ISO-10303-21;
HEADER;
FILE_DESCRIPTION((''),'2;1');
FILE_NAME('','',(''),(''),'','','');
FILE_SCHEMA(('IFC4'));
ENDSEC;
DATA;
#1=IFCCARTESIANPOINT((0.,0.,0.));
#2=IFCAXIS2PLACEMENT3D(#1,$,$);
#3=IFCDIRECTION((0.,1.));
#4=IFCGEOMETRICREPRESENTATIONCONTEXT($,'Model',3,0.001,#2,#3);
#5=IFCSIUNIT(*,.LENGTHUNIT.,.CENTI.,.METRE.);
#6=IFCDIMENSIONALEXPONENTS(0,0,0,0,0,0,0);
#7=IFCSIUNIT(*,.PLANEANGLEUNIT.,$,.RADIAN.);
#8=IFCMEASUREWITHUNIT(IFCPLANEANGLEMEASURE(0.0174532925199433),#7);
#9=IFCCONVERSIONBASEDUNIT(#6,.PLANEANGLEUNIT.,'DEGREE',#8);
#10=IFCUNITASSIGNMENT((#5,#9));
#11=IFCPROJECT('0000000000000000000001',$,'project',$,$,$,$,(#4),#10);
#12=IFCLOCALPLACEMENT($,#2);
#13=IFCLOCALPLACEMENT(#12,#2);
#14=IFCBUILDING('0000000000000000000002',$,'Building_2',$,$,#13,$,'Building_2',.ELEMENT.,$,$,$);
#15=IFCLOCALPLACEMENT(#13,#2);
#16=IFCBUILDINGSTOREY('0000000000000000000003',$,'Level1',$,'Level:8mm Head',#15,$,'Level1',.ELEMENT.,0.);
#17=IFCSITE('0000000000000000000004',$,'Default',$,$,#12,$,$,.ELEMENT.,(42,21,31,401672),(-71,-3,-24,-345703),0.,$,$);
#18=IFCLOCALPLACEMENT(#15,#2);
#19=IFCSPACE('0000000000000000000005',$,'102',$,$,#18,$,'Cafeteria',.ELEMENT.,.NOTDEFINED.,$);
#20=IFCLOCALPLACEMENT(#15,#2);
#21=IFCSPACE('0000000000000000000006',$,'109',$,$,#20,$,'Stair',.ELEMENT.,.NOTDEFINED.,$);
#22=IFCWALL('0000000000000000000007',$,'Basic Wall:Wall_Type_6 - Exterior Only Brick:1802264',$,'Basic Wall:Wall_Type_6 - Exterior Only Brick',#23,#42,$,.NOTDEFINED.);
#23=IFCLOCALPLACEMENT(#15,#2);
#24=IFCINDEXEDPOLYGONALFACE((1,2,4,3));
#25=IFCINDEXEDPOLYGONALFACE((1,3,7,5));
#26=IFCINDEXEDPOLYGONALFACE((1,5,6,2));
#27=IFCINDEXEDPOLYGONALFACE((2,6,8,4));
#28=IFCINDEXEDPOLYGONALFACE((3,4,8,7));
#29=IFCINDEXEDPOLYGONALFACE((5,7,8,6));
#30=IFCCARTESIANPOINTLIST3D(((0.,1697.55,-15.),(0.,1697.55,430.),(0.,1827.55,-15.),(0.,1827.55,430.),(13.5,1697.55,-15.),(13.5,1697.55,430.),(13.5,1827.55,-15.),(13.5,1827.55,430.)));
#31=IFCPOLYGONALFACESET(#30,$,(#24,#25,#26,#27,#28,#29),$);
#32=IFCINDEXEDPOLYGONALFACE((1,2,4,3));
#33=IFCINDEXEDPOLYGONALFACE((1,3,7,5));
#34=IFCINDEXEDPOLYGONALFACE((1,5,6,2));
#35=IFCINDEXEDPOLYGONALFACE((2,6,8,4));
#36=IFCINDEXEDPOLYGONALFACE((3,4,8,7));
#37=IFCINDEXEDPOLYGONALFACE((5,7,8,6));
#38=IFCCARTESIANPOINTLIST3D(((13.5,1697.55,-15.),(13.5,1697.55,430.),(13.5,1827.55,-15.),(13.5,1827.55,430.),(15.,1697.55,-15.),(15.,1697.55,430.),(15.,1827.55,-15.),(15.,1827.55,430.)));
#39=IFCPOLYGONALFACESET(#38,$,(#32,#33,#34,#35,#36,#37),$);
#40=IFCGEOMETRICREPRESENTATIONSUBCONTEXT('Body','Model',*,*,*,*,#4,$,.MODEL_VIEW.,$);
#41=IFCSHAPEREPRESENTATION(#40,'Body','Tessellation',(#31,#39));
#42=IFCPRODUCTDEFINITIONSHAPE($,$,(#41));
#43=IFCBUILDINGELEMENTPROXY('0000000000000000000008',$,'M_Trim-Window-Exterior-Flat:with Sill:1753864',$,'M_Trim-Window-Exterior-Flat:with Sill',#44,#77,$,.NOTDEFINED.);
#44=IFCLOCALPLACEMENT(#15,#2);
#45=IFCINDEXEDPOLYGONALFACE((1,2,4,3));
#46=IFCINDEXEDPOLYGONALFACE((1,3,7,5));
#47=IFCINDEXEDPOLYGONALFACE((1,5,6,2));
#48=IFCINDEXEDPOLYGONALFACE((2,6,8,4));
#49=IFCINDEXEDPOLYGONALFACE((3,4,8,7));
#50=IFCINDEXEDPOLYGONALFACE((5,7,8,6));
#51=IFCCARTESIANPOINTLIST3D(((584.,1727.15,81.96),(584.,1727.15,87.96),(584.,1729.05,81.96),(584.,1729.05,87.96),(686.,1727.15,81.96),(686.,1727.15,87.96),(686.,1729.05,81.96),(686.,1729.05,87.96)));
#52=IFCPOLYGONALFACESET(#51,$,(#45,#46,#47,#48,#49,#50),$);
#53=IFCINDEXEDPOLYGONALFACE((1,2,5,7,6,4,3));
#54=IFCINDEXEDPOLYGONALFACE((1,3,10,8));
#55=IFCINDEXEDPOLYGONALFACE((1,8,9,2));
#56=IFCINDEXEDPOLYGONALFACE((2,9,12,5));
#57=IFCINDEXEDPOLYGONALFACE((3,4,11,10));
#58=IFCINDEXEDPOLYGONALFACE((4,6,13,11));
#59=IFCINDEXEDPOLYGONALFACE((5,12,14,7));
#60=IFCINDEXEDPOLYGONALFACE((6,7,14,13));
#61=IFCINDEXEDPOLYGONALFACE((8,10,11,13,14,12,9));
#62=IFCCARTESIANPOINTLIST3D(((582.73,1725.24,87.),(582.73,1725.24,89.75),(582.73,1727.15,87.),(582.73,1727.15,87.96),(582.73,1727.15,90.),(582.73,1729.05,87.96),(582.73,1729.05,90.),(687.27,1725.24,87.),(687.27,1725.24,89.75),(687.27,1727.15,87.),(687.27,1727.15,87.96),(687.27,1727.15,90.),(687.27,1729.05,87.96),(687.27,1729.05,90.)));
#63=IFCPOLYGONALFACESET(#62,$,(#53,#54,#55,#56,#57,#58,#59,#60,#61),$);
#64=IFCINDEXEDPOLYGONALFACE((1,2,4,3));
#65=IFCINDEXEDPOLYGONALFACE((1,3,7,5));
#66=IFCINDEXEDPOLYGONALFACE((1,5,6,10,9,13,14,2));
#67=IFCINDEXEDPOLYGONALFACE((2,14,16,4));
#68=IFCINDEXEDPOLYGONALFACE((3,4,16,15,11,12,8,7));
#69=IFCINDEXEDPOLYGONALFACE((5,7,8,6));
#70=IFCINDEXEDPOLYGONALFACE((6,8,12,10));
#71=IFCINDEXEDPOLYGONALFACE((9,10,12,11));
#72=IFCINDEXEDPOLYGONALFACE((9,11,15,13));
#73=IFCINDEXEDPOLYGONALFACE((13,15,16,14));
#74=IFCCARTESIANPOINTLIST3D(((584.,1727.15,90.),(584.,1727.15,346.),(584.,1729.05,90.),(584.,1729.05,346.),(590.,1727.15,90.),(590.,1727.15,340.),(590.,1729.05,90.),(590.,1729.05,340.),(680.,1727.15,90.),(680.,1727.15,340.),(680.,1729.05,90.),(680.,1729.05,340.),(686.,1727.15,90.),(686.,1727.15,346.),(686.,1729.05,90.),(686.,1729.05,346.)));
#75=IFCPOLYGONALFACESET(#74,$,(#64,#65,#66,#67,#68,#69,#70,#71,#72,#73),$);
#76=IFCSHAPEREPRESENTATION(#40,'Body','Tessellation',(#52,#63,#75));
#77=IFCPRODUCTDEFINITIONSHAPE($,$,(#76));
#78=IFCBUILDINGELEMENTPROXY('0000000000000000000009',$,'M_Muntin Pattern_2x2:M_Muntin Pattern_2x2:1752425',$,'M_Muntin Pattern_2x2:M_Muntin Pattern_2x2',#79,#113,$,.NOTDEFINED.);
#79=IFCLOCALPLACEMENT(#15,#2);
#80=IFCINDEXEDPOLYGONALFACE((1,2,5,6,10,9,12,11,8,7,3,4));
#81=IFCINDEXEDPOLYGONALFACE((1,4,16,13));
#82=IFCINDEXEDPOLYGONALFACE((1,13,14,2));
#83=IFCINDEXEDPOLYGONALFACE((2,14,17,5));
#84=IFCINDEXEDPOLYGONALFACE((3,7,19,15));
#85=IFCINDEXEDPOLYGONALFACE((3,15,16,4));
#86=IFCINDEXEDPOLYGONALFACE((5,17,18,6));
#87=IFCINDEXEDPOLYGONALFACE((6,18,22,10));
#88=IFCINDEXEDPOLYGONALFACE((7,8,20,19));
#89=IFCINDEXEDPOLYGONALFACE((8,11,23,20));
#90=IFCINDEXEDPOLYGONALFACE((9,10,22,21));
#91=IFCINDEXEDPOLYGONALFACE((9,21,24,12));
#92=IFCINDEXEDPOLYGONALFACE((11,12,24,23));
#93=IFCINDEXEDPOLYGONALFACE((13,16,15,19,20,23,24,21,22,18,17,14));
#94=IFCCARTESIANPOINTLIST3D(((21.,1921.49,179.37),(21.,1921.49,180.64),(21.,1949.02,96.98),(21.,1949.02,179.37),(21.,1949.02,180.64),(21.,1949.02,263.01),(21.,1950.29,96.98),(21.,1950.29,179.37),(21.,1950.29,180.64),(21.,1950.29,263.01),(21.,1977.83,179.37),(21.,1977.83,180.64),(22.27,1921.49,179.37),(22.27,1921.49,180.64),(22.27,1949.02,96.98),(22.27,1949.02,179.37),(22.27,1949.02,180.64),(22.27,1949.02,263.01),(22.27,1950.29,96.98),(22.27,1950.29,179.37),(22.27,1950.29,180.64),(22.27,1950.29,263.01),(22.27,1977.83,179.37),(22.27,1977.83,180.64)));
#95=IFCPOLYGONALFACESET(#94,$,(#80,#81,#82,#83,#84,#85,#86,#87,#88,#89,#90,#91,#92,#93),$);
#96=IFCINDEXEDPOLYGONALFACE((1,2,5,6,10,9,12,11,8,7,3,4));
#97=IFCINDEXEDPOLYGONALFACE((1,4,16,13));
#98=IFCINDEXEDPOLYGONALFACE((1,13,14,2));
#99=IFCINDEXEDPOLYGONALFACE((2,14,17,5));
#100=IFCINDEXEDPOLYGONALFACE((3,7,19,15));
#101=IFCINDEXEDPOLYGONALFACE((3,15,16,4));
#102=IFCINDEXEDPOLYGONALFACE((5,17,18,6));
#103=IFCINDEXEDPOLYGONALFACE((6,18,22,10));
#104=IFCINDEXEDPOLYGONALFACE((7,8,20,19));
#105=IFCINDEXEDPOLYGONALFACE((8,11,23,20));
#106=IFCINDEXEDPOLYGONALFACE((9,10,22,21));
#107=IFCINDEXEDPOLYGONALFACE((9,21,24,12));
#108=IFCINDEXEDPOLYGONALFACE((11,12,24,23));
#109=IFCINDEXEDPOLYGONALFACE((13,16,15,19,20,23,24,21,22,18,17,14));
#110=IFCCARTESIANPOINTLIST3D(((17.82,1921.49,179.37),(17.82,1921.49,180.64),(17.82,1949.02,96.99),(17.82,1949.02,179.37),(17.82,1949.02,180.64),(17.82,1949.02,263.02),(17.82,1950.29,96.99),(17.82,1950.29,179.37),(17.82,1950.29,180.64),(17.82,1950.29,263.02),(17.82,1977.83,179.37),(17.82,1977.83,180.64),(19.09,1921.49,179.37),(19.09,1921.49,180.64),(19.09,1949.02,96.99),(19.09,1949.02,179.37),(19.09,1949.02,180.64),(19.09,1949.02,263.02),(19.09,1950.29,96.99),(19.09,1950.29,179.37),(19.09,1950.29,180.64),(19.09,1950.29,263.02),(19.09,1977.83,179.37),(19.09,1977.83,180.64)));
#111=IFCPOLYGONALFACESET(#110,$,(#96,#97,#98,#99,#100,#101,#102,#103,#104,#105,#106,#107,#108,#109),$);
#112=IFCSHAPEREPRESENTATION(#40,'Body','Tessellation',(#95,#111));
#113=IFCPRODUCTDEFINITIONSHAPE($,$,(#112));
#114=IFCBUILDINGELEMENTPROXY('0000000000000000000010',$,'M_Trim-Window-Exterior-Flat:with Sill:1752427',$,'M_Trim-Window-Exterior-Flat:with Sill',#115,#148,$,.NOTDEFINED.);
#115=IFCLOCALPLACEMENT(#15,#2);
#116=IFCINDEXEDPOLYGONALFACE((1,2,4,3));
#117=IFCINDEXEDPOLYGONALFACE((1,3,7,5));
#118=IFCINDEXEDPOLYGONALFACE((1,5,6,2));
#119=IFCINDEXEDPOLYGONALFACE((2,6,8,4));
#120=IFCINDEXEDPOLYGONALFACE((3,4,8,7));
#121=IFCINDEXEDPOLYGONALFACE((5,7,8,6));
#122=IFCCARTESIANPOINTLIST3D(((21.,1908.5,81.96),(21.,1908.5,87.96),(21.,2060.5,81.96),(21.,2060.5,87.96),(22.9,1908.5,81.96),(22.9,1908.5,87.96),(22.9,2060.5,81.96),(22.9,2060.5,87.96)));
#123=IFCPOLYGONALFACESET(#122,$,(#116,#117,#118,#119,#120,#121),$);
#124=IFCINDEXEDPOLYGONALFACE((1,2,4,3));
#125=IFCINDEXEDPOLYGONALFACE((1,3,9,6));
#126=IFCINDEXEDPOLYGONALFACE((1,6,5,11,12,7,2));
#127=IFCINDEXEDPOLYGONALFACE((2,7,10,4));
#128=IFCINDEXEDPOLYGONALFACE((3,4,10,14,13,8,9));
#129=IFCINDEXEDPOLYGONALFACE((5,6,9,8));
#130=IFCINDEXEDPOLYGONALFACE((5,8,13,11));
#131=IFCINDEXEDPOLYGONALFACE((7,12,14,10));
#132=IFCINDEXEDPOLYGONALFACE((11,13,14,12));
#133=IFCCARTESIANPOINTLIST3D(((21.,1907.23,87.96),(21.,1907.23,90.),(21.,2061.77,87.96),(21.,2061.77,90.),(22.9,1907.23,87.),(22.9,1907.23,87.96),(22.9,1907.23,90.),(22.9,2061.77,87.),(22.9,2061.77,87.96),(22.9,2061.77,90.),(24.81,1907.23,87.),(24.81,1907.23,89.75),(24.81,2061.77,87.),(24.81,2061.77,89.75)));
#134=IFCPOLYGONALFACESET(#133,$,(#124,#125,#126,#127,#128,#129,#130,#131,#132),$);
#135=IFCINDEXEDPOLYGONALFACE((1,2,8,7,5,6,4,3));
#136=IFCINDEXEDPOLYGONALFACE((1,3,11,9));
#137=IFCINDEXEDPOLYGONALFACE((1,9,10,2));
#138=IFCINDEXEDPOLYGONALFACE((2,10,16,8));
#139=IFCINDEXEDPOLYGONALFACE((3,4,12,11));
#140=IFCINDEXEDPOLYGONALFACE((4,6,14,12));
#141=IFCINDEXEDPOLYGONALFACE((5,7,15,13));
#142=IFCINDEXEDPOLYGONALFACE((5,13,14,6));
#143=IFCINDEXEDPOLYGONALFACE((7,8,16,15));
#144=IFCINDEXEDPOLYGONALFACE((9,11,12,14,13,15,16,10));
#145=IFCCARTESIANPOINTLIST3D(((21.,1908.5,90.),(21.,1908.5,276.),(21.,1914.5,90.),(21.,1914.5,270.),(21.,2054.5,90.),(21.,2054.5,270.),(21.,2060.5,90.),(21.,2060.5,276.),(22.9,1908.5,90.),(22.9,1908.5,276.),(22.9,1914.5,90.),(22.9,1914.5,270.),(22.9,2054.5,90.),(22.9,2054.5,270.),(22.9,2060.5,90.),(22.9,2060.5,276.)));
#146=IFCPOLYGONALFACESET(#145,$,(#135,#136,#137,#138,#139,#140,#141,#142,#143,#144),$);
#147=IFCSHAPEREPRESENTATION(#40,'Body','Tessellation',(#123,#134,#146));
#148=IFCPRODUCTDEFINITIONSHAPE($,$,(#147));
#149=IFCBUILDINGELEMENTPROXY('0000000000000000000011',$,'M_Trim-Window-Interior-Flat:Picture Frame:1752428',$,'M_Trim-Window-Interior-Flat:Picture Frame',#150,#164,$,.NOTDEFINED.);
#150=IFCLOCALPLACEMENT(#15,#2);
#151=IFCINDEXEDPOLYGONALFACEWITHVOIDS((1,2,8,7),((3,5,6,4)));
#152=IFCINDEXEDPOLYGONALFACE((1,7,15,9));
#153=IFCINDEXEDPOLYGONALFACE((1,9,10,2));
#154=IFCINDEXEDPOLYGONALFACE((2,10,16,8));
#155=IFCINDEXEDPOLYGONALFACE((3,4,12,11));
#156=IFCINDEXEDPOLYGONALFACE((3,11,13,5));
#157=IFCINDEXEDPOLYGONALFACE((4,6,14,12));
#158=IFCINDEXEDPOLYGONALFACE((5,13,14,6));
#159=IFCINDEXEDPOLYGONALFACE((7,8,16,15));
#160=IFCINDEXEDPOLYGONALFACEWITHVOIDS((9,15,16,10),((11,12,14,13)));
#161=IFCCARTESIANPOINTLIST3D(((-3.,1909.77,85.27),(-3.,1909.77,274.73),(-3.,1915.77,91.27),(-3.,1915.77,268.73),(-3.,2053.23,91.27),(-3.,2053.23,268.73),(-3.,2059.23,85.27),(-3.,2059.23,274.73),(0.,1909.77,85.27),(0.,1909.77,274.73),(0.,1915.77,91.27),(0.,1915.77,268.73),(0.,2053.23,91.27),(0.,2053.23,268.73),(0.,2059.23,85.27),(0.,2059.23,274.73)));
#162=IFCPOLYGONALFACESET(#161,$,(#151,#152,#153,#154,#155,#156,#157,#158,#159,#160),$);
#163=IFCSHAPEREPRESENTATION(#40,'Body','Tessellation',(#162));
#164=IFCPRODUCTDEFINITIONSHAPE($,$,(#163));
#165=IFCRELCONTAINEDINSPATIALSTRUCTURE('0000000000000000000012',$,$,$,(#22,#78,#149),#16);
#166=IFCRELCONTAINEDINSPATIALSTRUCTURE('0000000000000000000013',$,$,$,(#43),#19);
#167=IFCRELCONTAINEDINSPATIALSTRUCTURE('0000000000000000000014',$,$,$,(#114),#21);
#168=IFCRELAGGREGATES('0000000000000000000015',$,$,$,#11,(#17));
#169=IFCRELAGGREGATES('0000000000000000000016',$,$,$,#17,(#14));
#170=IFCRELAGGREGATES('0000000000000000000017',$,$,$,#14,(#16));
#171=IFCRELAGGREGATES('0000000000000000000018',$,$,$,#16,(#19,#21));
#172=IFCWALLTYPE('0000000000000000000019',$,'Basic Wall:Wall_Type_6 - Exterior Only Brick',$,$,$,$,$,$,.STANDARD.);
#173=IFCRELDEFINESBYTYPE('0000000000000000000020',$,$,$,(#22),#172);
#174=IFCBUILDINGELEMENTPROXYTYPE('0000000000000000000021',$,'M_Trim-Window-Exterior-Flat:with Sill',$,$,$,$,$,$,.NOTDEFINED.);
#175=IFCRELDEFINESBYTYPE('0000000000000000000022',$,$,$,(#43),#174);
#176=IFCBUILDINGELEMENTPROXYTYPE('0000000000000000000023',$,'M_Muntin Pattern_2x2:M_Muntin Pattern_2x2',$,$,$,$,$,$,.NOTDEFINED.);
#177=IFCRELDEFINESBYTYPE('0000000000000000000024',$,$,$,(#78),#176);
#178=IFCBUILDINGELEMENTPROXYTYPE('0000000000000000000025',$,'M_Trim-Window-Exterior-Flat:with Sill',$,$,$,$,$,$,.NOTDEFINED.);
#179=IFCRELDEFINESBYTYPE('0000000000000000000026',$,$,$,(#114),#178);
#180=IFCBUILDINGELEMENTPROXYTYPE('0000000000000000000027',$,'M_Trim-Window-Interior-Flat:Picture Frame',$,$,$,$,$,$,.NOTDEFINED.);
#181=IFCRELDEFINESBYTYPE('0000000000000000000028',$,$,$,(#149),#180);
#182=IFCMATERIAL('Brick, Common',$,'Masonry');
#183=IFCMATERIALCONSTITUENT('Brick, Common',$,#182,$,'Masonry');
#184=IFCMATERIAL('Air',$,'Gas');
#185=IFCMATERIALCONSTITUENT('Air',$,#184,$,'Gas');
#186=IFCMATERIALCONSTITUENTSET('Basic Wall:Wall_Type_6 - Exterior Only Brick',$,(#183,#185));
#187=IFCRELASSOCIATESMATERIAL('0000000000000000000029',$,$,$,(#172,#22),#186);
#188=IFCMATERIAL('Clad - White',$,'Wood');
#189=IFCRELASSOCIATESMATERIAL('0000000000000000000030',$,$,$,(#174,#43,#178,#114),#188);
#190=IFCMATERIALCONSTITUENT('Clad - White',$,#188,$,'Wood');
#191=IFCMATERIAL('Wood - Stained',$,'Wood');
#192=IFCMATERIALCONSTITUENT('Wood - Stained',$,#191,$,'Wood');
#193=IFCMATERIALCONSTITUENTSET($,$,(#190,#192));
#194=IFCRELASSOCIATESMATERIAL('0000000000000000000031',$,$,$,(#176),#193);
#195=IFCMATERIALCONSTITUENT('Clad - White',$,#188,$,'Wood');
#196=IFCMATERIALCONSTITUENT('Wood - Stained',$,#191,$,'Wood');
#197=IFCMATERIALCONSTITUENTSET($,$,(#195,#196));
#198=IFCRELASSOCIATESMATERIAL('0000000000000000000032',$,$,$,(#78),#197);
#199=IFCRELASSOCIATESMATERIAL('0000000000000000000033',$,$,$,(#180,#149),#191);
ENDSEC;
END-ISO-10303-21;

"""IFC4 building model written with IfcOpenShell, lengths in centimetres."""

from ifc_helpers import new_model, entity, si_unit, converted_unit, direction, frame, origin, place, context, subcontext, project, spatial, indexed_curve, outline, extrude, source, transform, mapped, material, constituent, constituent_set, type_object, type_shapes, element, save


model = new_model("IFC4")

# Units and contexts
model_context = context("Model", 3, precision=0.001, world=origin(), true_north=direction((0.0, 1.0)))
body_context = subcontext(model_context, "Body", "Model", "MODEL_VIEW")
ifc_project = project(units=[si_unit("LENGTHUNIT", "METRE", prefix="CENTI"), converted_unit("PLANEANGLEUNIT", "DEGREE", entity("IfcPlaneAngleMeasure", 0.0174532925199433), si_unit("PLANEANGLEUNIT", "RADIAN"), dimensions=[0, 0, 0, 0, 0, 0, 0])], contexts=[model_context])

# Site, building, storey
site_placement = place(None, origin())
site = spatial("IfcSite", under=ifc_project, at=site_placement, Name="Default", CompositionType="ELEMENT", RefLatitude=(42, 21, 31, 401672), RefLongitude=(-71, -3, -24, -345703), RefElevation=0.0)
building_placement = place(site_placement, origin())
building = spatial("IfcBuilding", under=site, at=building_placement, Name="Building_2", LongName="Building_2", CompositionType="ELEMENT")
storey_placement = place(building_placement, origin())
storey = spatial("IfcBuildingStorey", under=building, at=storey_placement, Name="Level1", ObjectType="Level:8mm Head", LongName="Level1", CompositionType="ELEMENT", Elevation=0.0)

# Shared definitions
ifc_material_1 = material(Name="Brick, Common", Category="Masonry")
ifc_material_2 = material(Name="Air", Category="Gas")

# Shared definitions
ifc_constituent_1 = constituent(ifc_material_1, Name="Brick, Common", Category="Masonry")
ifc_constituent_2 = constituent(ifc_material_2, Name="Air", Category="Gas")
ifc_constituent_set_1 = constituent_set(constituents=[ifc_constituent_1, ifc_constituent_2], Name="Basic Wall:Wall_Type_6 - Exterior Only Brick")
wall_type_1 = type_object("IfcWallType", Name="Basic Wall:Wall_Type_6 - Exterior Only Brick", PredefinedType="STANDARD", material=ifc_constituent_set_1)

# Wall
wall_1_placement = place(storey_placement, frame((7.5, 1697.55, -15.0), z_axis=(0.0, 0.0, 1.0), x_axis=(0.0, 1.0, 0.0)))
element("IfcWall", 1, at=wall_1_placement, inside=storey, type_object=wall_type_1, material=ifc_constituent_set_1, Name="Basic Wall:Wall_Type_6 - Exterior Only Brick:1802264", ObjectType="Basic Wall:Wall_Type_6 - Exterior Only Brick", PredefinedType="NOTDEFINED", context=body_context, shape_type="SweptSolid", body=[
    extrude(outline(indexed_curve([(-6.75, -65.0), (6.75, -65.0), (6.75, 65.0), (-6.75, 65.0), (-6.75, -65.0)], self_intersect=False)), frame((65.0, 0.75, 0.0), z_axis=(0.0, 0.0, 1.0), x_axis=(0.0, -1.0, 0.0)), (0.0, 0.0, 1.0), 445.0),
    extrude(outline(indexed_curve([(-0.75, -65.0), (0.75, -65.0), (0.75, 65.0), (-0.75, 65.0), (-0.75, -65.0)], self_intersect=False)), frame((65.0, -6.75, 0.0), z_axis=(0.0, 0.0, 1.0), x_axis=(0.0, 1.0, 0.0)), (0.0, 0.0, 1.0), 445.0),
])

# Shared definitions
space_1_placement = place(storey_placement, origin())
space_1 = spatial("IfcSpace", under=storey, at=space_1_placement, Name="102", LongName="Cafeteria", CompositionType="ELEMENT", PredefinedType="NOTDEFINED")

# Building element proxies
ifc_material_3 = material(Name="Clad - White", Category="Wood")
building_element_proxy_type_1 = type_object("IfcBuildingElementProxyType", Name="M_Trim-Window-Exterior-Flat:with Sill", PredefinedType="NOTDEFINED", material=ifc_material_3)
shared_shape_1 = source(origin(), body_context, "Body", "SweptSolid", [
    extrude(outline(indexed_curve([(-3.0, -51.0), (3.0, -51.0), (3.0, 51.0), (-3.0, 51.0), (-3.0, -51.0)], self_intersect=False)), frame((0.0, 255.04, 0.0), z_axis=(0.0, 0.0, 1.0), x_axis=(0.0, 1.0, 0.0)), (0.0, 0.0, 1.0), 1.91),
    extrude(outline(indexed_curve([(-1.52, -1.9), (1.23, -1.9), (1.48, 0.0), (1.48, 1.9), (-0.57, 1.9), (-0.57, 0.0), (-1.52, 0.0), (-1.52, -1.9)], self_intersect=False)), frame((-52.27, 251.48, 1.9), z_axis=(1.0, 0.0, 0.0), x_axis=(0.0, -1.0, 0.0)), (0.0, 0.0, 1.0), 104.54),
    extrude(outline(indexed_curve([(-51.0, -129.5), (51.0, -129.5), (51.0, 126.5), (45.0, 126.5), (45.0, -123.5), (-45.0, -123.5), (-45.0, 126.5), (-51.0, 126.5), (-51.0, -129.5)], self_intersect=False)), frame((0.0, 123.5, 0.0)), (0.0, 0.0, 1.0), 1.91),
])
type_shapes(building_element_proxy_type_1, [shared_shape_1])
proxy_1_placement = place(space_1_placement, frame((635.0, 1729.05, 340.0), z_axis=(0.0, -1.0, 0.0), x_axis=(-1.0, 0.0, 0.0)))
element("IfcBuildingElementProxy", 2, at=proxy_1_placement, inside=space_1, type_object=building_element_proxy_type_1, material=ifc_material_3, Name="M_Trim-Window-Exterior-Flat:with Sill:1753864", ObjectType="M_Trim-Window-Exterior-Flat:with Sill", PredefinedType="NOTDEFINED", context=body_context, shape_type="MappedRepresentation", body=[
    mapped(shared_shape_1, transform((0.0, 0.0, 0.0), scale=1.0)),
])
ifc_constituent_3 = constituent(ifc_material_3, Name="Clad - White", Category="Wood")
ifc_material_4 = material(Name="Wood - Stained", Category="Wood")
ifc_constituent_4 = constituent(ifc_material_4, Name="Wood - Stained", Category="Wood")
ifc_constituent_set_2 = constituent_set(constituents=[ifc_constituent_3, ifc_constituent_4])
ifc_constituent_5 = constituent(ifc_material_3, Name="Clad - White", Category="Wood")
ifc_constituent_6 = constituent(ifc_material_4, Name="Wood - Stained", Category="Wood")
ifc_constituent_set_3 = constituent_set(constituents=[ifc_constituent_5, ifc_constituent_6])
building_element_proxy_type_2 = type_object("IfcBuildingElementProxyType", Name="M_Muntin Pattern_2x2:M_Muntin Pattern_2x2", PredefinedType="NOTDEFINED", material=ifc_constituent_set_3)
shared_shape_2 = source(origin(), body_context, "Body", "SweptSolid", [
    extrude(outline(indexed_curve([(0.64, -0.64), (83.01, -0.64), (83.01, 0.63), (0.64, 0.63), (0.64, 28.17), (-0.63, 28.17), (-0.63, 0.63), (-83.02, 0.63), (-83.02, -0.64), (-0.63, -0.64), (-0.63, -28.17), (0.64, -28.17), (0.64, -0.64)], self_intersect=False)), frame((0.0, -2.22, 83.01), z_axis=(0.0, 1.0, 0.0), x_axis=(0.0, 0.0, 1.0)), (0.0, 0.0, 1.0), 1.27),
    extrude(outline(indexed_curve([(0.64, -0.64), (83.02, -0.64), (83.02, 0.63), (0.64, 0.63), (0.64, 28.17), (-0.63, 28.17), (-0.63, 0.63), (-83.02, 0.63), (-83.02, -0.64), (-0.63, -0.64), (-0.63, -28.17), (0.64, -28.17), (0.64, -0.64)], self_intersect=False)), frame((0.0, 0.95, 83.02), z_axis=(0.0, 1.0, 0.0), x_axis=(0.0, 0.0, 1.0)), (0.0, 0.0, 1.0), 1.27),
])
type_shapes(building_element_proxy_type_2, [shared_shape_2])
proxy_2_placement = place(storey_placement, frame((20.05, 1949.66, 96.99), z_axis=(0.0, 0.0, 1.0), x_axis=(0.0, 1.0, 0.0)))
element("IfcBuildingElementProxy", 3, at=proxy_2_placement, inside=storey, type_object=building_element_proxy_type_2, material=ifc_constituent_set_2, Name="M_Muntin Pattern_2x2:M_Muntin Pattern_2x2:1752425", ObjectType="M_Muntin Pattern_2x2:M_Muntin Pattern_2x2", PredefinedType="NOTDEFINED", context=body_context, shape_type="MappedRepresentation", body=[
    mapped(shared_shape_2, transform((0.0, 0.0, 0.0), scale=1.0)),
])

# Shared definitions
space_2_placement = place(storey_placement, origin())
space_2 = spatial("IfcSpace", under=storey, at=space_2_placement, Name="109", LongName="Stair", CompositionType="ELEMENT", PredefinedType="NOTDEFINED")

# Building element proxies
building_element_proxy_type_3 = type_object("IfcBuildingElementProxyType", Name="M_Trim-Window-Exterior-Flat:with Sill", PredefinedType="NOTDEFINED", material=ifc_material_3)
shared_shape_3 = source(origin(), body_context, "Body", "SweptSolid", [
    extrude(outline(indexed_curve([(-76.0, -3.0), (76.0, -3.0), (76.0, 3.0), (-76.0, 3.0), (-76.0, -3.0)], self_intersect=False)), frame((0.0, -185.04, 0.0), z_axis=(0.0, 0.0, 1.0), x_axis=(-1.0, 0.0, 0.0)), (0.0, 0.0, 1.0), 1.91),
    extrude(outline(indexed_curve([(-1.9, -1.52), (0.0, -1.52), (0.0, -0.57), (1.9, -0.57), (1.9, 1.48), (0.0, 1.48), (-1.9, 1.23), (-1.9, -1.52)], self_intersect=False)), frame((-77.27, -181.48, 1.9), z_axis=(1.0, 0.0, 0.0), x_axis=(0.0, 0.0, -1.0)), (0.0, 0.0, 1.0), 154.54),
    extrude(outline(indexed_curve([(-94.5, -76.0), (91.5, -76.0), (91.5, -70.0), (-88.5, -70.0), (-88.5, 70.0), (91.5, 70.0), (91.5, 76.0), (-94.5, 76.0), (-94.5, -76.0)], self_intersect=False)), frame((0.0, -88.5, 0.0), z_axis=(0.0, 0.0, 1.0), x_axis=(0.0, -1.0, 0.0)), (0.0, 0.0, 1.0), 1.91),
])
type_shapes(building_element_proxy_type_3, [shared_shape_3])
proxy_3_placement = place(space_2_placement, frame((21.0, 1984.5, 270.0), z_axis=(1.0, 0.0, 0.0), x_axis=(0.0, 1.0, 0.0)))
element("IfcBuildingElementProxy", 4, at=proxy_3_placement, inside=space_2, type_object=building_element_proxy_type_3, material=ifc_material_3, Name="M_Trim-Window-Exterior-Flat:with Sill:1752427", ObjectType="M_Trim-Window-Exterior-Flat:with Sill", PredefinedType="NOTDEFINED", context=body_context, shape_type="MappedRepresentation", body=[
    mapped(shared_shape_3, transform((0.0, 0.0, 0.0), scale=1.0)),
])
building_element_proxy_type_4 = type_object("IfcBuildingElementProxyType", Name="M_Trim-Window-Interior-Flat:Picture Frame", PredefinedType="NOTDEFINED", material=ifc_material_4)
shared_shape_4 = source(origin(), body_context, "Body", "SweptSolid", [
    extrude(outline(indexed_curve([(-74.73, -94.73), (74.73, -94.73), (74.73, 94.73), (-74.73, 94.73), (-74.73, -94.73)], self_intersect=False), holes=[indexed_curve([(-68.73, -88.73), (-68.73, 88.73), (68.73, 88.73), (68.73, -88.73), (-68.73, -88.73)], self_intersect=False)]), frame((0.0, -90.0, 0.0), z_axis=(0.0, 0.0, 1.0), x_axis=(-1.0, 0.0, 0.0)), (0.0, 0.0, 1.0), 3.0),
])
type_shapes(building_element_proxy_type_4, [shared_shape_4])
proxy_4_placement = place(storey_placement, frame((0.0, 1984.5, 270.0), z_axis=(-1.0, 0.0, 0.0), x_axis=(0.0, -1.0, 0.0)))
element("IfcBuildingElementProxy", 5, at=proxy_4_placement, inside=storey, type_object=building_element_proxy_type_4, material=ifc_material_4, Name="M_Trim-Window-Interior-Flat:Picture Frame:1752428", ObjectType="M_Trim-Window-Interior-Flat:Picture Frame", PredefinedType="NOTDEFINED", context=body_context, shape_type="MappedRepresentation", body=[
    mapped(shared_shape_4, transform((0.0, 0.0, 0.0), scale=1.0)),
])

save(model, "model.ifc")
